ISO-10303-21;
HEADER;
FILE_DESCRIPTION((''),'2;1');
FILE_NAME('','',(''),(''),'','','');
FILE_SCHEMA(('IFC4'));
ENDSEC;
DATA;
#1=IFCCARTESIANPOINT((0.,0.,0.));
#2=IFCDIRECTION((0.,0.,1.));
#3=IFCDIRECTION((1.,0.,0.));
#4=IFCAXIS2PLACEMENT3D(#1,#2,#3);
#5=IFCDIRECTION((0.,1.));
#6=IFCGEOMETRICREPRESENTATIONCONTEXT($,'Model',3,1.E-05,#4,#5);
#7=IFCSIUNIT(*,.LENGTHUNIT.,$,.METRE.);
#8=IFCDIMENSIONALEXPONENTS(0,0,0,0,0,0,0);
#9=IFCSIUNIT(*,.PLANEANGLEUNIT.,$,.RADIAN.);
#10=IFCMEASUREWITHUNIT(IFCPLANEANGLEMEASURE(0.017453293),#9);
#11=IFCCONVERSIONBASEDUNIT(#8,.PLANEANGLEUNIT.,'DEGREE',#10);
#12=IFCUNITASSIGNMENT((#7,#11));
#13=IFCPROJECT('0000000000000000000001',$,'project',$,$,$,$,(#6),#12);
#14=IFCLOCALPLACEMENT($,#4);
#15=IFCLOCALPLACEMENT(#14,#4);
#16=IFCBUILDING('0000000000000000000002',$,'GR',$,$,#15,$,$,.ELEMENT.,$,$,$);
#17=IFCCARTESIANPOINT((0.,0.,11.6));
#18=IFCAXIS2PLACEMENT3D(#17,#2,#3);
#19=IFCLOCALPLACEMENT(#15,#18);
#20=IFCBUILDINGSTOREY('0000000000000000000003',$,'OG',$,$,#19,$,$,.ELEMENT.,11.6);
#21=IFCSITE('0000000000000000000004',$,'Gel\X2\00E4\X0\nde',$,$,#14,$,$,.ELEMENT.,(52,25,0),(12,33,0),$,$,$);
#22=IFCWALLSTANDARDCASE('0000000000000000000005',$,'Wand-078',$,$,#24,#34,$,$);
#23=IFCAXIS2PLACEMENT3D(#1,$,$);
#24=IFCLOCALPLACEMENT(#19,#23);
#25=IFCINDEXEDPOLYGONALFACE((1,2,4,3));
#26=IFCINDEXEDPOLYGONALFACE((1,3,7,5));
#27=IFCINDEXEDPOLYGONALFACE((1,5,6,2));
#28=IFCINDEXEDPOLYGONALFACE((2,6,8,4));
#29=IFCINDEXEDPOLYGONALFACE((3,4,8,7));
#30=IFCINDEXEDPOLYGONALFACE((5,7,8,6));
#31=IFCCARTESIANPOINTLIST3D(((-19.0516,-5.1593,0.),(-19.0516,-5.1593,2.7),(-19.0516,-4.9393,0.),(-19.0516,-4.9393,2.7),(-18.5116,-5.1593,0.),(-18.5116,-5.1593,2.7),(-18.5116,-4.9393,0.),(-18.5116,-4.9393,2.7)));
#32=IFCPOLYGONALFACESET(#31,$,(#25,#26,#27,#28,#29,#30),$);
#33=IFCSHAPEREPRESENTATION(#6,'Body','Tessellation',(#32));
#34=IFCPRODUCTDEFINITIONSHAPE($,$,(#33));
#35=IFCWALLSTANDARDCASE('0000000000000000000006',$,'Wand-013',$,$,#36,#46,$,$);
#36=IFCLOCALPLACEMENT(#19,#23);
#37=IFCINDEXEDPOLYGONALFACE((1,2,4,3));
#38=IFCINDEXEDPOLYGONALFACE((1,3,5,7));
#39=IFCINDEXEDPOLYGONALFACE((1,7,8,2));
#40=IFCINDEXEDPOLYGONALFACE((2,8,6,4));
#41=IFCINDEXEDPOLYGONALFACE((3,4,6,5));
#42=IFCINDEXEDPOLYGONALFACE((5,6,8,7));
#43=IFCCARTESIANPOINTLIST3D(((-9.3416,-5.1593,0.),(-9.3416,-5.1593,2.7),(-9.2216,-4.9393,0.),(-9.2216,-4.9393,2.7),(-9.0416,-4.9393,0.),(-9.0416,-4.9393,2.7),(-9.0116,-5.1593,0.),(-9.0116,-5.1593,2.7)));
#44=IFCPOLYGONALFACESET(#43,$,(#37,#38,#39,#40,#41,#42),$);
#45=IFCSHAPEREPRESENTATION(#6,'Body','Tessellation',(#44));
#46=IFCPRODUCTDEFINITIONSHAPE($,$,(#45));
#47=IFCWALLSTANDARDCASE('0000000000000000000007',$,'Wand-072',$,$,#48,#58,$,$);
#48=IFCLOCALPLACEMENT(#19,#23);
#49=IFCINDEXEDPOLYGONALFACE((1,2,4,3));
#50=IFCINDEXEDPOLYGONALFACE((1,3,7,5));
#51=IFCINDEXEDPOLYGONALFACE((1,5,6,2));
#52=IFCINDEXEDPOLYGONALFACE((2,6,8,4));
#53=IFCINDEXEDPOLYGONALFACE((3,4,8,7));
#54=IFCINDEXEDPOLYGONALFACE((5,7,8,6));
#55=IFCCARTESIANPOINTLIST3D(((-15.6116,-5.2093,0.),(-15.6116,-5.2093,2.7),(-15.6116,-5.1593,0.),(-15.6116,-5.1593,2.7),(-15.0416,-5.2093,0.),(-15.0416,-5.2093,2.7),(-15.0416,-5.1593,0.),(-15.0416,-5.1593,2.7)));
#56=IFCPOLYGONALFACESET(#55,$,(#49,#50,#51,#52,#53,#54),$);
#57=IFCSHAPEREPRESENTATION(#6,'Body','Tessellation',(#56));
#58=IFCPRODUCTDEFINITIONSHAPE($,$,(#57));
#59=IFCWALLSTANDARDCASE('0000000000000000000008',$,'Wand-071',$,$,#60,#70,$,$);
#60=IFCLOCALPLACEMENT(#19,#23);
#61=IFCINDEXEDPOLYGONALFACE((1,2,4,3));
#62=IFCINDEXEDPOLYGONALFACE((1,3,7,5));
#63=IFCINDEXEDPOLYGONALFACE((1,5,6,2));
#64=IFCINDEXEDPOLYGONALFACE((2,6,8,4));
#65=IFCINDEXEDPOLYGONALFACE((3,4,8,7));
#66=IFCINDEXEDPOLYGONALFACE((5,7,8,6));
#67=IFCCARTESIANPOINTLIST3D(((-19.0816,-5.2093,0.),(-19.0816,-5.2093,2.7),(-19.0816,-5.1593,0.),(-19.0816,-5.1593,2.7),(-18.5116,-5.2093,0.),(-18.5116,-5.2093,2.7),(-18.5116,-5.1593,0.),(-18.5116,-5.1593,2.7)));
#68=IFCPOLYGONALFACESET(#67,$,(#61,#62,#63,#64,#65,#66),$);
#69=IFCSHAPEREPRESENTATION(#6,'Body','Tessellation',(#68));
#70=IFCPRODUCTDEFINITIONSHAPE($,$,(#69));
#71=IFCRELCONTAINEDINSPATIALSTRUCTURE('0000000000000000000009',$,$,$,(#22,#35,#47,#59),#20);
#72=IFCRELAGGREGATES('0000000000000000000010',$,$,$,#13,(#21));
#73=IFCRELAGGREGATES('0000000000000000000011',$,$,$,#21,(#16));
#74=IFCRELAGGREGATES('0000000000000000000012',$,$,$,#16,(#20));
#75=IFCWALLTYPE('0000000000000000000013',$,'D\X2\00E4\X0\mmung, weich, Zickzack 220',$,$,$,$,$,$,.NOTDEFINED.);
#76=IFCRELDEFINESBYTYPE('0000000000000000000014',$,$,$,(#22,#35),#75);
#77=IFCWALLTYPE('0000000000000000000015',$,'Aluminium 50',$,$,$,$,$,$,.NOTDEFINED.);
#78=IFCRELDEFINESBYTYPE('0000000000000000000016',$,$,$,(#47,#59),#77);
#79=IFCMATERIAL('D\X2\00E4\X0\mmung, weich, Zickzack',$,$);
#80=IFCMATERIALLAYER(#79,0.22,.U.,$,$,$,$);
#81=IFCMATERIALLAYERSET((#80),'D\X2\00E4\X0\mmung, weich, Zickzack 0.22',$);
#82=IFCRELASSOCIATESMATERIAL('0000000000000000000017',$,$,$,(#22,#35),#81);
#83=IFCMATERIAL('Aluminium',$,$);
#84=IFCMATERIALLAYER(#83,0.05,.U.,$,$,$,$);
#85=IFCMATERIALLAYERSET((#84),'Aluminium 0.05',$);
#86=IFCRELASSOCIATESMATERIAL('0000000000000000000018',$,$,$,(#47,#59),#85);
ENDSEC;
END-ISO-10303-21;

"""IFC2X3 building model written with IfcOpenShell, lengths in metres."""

from ifc_helpers import new_model, entity, si_unit, converted_unit, direction, frame, origin_with_axes, place, context, project, spatial, polyline, outline, extrude, material, layer, layer_set, layer_usage, type_object, element, save


model = new_model("IFC2X3")

# Units and contexts
model_context = context("Model", 3, precision=1e-05, world=origin_with_axes(), true_north=direction((0.0, 1.0)))
ifc_project = project(units=[si_unit("LENGTHUNIT", "METRE"), converted_unit("PLANEANGLEUNIT", "DEGREE", entity("IfcPlaneAngleMeasure", 0.017453293), si_unit("PLANEANGLEUNIT", "RADIAN"), dimensions=[0, 0, 0, 0, 0, 0, 0])], contexts=[model_context])

# Site, building, storey
site_placement = place(None, origin_with_axes())
site = spatial("IfcSite", under=ifc_project, at=site_placement, Name="Gelände", CompositionType="ELEMENT", RefLatitude=(52, 25, 0), RefLongitude=(12, 33, 0))
building_placement = place(site_placement, origin_with_axes())
building = spatial("IfcBuilding", under=site, at=building_placement, Name="GR", CompositionType="ELEMENT")
storey_placement = place(building_placement, frame((0.0, 0.0, 11.6), z_axis=(0.0, 0.0, 1.0), x_axis=(1.0, 0.0, 0.0)))
storey = spatial("IfcBuildingStorey", under=building, at=storey_placement, Name="OG", CompositionType="ELEMENT", Elevation=11.6)

# Shared definitions
ifc_material_1 = material(Name="Dämmung, weich, Zickzack")

# Walls
ifc_layer_1 = layer(ifc_material_1, 0.22, ventilated="UNKNOWN")
ifc_layer_set_1 = layer_set([ifc_layer_1], Name="Dämmung, weich, Zickzack 0.22")
wall_type_1 = type_object("IfcWallType", Name="Dämmung, weich, Zickzack 220", PredefinedType="NOTDEFINED")
ifc_layer_usage_1 = layer_usage(ifc_layer_set_1, "AXIS2", "NEGATIVE", 0.0)
wall_1_placement = place(storey_placement, frame((-19.0516, -4.9393, 0.0), z_axis=(0.0, 0.0, 1.0), x_axis=(1.0, 0.0, 0.0)))
element("IfcWallStandardCase", 1, at=wall_1_placement, inside=storey, type_object=wall_type_1, material=ifc_layer_usage_1, Name="Wand-078", context=model_context, shape_type="SweptSolid", body=[
    extrude(outline(polyline([(0.0, -0.22), (0.54, -0.22), (0.54, 0.0), (0.0, 0.0), (0.0, -0.22)])), origin_with_axes(), (0.0, 0.0, 1.0), 2.7),
])
ifc_layer_usage_2 = layer_usage(ifc_layer_set_1, "AXIS2", "NEGATIVE", 0.0)
wall_2_placement = place(storey_placement, frame((-9.0416, -5.1593, 0.0), z_axis=(0.0, 0.0, 1.0), x_axis=(-1.0, 0.0, 0.0)))
element("IfcWallStandardCase", 2, at=wall_2_placement, inside=storey, type_object=wall_type_1, material=ifc_layer_usage_2, Name="Wand-013", context=model_context, shape_type="SweptSolid", body=[
    extrude(outline(polyline([(0.0, -0.22), (0.18, -0.22), (0.3, 0.0), (-0.03, 0.0), (0.0, -0.22)])), origin_with_axes(), (0.0, 0.0, 1.0), 2.7),
])
ifc_material_2 = material(Name="Aluminium")
ifc_layer_2 = layer(ifc_material_2, 0.05, ventilated="UNKNOWN")
ifc_layer_set_2 = layer_set([ifc_layer_2], Name="Aluminium 0.05")
ifc_layer_usage_3 = layer_usage(ifc_layer_set_2, "AXIS2", "NEGATIVE", 0.0)
wall_type_2 = type_object("IfcWallType", Name="Aluminium 50", PredefinedType="NOTDEFINED")
wall_3_placement = place(storey_placement, frame((-15.6116, -5.1593, 0.0), z_axis=(0.0, 0.0, 1.0), x_axis=(1.0, 0.0, 0.0)))
element("IfcWallStandardCase", 3, at=wall_3_placement, inside=storey, type_object=wall_type_2, material=ifc_layer_usage_3, Name="Wand-072", context=model_context, shape_type="SweptSolid", body=[
    extrude(outline(polyline([(0.0, -0.05), (0.57, -0.05), (0.57, 0.0), (0.0, 0.0), (0.0, -0.05)])), origin_with_axes(), (0.0, 0.0, 1.0), 2.7),
])
ifc_layer_usage_4 = layer_usage(ifc_layer_set_2, "AXIS2", "NEGATIVE", 0.0)
wall_4_placement = place(storey_placement, frame((-19.0816, -5.1593, 0.0), z_axis=(0.0, 0.0, 1.0), x_axis=(1.0, 0.0, 0.0)))
element("IfcWallStandardCase", 4, at=wall_4_placement, inside=storey, type_object=wall_type_2, material=ifc_layer_usage_4, Name="Wand-071", context=model_context, shape_type="SweptSolid", body=[
    extrude(outline(polyline([(0.0, -0.05), (0.57, -0.05), (0.57, 0.0), (0.0, 0.0), (0.0, -0.05)])), origin_with_axes(), (0.0, 0.0, 1.0), 2.7),
])

save(model, "model.ifc")
